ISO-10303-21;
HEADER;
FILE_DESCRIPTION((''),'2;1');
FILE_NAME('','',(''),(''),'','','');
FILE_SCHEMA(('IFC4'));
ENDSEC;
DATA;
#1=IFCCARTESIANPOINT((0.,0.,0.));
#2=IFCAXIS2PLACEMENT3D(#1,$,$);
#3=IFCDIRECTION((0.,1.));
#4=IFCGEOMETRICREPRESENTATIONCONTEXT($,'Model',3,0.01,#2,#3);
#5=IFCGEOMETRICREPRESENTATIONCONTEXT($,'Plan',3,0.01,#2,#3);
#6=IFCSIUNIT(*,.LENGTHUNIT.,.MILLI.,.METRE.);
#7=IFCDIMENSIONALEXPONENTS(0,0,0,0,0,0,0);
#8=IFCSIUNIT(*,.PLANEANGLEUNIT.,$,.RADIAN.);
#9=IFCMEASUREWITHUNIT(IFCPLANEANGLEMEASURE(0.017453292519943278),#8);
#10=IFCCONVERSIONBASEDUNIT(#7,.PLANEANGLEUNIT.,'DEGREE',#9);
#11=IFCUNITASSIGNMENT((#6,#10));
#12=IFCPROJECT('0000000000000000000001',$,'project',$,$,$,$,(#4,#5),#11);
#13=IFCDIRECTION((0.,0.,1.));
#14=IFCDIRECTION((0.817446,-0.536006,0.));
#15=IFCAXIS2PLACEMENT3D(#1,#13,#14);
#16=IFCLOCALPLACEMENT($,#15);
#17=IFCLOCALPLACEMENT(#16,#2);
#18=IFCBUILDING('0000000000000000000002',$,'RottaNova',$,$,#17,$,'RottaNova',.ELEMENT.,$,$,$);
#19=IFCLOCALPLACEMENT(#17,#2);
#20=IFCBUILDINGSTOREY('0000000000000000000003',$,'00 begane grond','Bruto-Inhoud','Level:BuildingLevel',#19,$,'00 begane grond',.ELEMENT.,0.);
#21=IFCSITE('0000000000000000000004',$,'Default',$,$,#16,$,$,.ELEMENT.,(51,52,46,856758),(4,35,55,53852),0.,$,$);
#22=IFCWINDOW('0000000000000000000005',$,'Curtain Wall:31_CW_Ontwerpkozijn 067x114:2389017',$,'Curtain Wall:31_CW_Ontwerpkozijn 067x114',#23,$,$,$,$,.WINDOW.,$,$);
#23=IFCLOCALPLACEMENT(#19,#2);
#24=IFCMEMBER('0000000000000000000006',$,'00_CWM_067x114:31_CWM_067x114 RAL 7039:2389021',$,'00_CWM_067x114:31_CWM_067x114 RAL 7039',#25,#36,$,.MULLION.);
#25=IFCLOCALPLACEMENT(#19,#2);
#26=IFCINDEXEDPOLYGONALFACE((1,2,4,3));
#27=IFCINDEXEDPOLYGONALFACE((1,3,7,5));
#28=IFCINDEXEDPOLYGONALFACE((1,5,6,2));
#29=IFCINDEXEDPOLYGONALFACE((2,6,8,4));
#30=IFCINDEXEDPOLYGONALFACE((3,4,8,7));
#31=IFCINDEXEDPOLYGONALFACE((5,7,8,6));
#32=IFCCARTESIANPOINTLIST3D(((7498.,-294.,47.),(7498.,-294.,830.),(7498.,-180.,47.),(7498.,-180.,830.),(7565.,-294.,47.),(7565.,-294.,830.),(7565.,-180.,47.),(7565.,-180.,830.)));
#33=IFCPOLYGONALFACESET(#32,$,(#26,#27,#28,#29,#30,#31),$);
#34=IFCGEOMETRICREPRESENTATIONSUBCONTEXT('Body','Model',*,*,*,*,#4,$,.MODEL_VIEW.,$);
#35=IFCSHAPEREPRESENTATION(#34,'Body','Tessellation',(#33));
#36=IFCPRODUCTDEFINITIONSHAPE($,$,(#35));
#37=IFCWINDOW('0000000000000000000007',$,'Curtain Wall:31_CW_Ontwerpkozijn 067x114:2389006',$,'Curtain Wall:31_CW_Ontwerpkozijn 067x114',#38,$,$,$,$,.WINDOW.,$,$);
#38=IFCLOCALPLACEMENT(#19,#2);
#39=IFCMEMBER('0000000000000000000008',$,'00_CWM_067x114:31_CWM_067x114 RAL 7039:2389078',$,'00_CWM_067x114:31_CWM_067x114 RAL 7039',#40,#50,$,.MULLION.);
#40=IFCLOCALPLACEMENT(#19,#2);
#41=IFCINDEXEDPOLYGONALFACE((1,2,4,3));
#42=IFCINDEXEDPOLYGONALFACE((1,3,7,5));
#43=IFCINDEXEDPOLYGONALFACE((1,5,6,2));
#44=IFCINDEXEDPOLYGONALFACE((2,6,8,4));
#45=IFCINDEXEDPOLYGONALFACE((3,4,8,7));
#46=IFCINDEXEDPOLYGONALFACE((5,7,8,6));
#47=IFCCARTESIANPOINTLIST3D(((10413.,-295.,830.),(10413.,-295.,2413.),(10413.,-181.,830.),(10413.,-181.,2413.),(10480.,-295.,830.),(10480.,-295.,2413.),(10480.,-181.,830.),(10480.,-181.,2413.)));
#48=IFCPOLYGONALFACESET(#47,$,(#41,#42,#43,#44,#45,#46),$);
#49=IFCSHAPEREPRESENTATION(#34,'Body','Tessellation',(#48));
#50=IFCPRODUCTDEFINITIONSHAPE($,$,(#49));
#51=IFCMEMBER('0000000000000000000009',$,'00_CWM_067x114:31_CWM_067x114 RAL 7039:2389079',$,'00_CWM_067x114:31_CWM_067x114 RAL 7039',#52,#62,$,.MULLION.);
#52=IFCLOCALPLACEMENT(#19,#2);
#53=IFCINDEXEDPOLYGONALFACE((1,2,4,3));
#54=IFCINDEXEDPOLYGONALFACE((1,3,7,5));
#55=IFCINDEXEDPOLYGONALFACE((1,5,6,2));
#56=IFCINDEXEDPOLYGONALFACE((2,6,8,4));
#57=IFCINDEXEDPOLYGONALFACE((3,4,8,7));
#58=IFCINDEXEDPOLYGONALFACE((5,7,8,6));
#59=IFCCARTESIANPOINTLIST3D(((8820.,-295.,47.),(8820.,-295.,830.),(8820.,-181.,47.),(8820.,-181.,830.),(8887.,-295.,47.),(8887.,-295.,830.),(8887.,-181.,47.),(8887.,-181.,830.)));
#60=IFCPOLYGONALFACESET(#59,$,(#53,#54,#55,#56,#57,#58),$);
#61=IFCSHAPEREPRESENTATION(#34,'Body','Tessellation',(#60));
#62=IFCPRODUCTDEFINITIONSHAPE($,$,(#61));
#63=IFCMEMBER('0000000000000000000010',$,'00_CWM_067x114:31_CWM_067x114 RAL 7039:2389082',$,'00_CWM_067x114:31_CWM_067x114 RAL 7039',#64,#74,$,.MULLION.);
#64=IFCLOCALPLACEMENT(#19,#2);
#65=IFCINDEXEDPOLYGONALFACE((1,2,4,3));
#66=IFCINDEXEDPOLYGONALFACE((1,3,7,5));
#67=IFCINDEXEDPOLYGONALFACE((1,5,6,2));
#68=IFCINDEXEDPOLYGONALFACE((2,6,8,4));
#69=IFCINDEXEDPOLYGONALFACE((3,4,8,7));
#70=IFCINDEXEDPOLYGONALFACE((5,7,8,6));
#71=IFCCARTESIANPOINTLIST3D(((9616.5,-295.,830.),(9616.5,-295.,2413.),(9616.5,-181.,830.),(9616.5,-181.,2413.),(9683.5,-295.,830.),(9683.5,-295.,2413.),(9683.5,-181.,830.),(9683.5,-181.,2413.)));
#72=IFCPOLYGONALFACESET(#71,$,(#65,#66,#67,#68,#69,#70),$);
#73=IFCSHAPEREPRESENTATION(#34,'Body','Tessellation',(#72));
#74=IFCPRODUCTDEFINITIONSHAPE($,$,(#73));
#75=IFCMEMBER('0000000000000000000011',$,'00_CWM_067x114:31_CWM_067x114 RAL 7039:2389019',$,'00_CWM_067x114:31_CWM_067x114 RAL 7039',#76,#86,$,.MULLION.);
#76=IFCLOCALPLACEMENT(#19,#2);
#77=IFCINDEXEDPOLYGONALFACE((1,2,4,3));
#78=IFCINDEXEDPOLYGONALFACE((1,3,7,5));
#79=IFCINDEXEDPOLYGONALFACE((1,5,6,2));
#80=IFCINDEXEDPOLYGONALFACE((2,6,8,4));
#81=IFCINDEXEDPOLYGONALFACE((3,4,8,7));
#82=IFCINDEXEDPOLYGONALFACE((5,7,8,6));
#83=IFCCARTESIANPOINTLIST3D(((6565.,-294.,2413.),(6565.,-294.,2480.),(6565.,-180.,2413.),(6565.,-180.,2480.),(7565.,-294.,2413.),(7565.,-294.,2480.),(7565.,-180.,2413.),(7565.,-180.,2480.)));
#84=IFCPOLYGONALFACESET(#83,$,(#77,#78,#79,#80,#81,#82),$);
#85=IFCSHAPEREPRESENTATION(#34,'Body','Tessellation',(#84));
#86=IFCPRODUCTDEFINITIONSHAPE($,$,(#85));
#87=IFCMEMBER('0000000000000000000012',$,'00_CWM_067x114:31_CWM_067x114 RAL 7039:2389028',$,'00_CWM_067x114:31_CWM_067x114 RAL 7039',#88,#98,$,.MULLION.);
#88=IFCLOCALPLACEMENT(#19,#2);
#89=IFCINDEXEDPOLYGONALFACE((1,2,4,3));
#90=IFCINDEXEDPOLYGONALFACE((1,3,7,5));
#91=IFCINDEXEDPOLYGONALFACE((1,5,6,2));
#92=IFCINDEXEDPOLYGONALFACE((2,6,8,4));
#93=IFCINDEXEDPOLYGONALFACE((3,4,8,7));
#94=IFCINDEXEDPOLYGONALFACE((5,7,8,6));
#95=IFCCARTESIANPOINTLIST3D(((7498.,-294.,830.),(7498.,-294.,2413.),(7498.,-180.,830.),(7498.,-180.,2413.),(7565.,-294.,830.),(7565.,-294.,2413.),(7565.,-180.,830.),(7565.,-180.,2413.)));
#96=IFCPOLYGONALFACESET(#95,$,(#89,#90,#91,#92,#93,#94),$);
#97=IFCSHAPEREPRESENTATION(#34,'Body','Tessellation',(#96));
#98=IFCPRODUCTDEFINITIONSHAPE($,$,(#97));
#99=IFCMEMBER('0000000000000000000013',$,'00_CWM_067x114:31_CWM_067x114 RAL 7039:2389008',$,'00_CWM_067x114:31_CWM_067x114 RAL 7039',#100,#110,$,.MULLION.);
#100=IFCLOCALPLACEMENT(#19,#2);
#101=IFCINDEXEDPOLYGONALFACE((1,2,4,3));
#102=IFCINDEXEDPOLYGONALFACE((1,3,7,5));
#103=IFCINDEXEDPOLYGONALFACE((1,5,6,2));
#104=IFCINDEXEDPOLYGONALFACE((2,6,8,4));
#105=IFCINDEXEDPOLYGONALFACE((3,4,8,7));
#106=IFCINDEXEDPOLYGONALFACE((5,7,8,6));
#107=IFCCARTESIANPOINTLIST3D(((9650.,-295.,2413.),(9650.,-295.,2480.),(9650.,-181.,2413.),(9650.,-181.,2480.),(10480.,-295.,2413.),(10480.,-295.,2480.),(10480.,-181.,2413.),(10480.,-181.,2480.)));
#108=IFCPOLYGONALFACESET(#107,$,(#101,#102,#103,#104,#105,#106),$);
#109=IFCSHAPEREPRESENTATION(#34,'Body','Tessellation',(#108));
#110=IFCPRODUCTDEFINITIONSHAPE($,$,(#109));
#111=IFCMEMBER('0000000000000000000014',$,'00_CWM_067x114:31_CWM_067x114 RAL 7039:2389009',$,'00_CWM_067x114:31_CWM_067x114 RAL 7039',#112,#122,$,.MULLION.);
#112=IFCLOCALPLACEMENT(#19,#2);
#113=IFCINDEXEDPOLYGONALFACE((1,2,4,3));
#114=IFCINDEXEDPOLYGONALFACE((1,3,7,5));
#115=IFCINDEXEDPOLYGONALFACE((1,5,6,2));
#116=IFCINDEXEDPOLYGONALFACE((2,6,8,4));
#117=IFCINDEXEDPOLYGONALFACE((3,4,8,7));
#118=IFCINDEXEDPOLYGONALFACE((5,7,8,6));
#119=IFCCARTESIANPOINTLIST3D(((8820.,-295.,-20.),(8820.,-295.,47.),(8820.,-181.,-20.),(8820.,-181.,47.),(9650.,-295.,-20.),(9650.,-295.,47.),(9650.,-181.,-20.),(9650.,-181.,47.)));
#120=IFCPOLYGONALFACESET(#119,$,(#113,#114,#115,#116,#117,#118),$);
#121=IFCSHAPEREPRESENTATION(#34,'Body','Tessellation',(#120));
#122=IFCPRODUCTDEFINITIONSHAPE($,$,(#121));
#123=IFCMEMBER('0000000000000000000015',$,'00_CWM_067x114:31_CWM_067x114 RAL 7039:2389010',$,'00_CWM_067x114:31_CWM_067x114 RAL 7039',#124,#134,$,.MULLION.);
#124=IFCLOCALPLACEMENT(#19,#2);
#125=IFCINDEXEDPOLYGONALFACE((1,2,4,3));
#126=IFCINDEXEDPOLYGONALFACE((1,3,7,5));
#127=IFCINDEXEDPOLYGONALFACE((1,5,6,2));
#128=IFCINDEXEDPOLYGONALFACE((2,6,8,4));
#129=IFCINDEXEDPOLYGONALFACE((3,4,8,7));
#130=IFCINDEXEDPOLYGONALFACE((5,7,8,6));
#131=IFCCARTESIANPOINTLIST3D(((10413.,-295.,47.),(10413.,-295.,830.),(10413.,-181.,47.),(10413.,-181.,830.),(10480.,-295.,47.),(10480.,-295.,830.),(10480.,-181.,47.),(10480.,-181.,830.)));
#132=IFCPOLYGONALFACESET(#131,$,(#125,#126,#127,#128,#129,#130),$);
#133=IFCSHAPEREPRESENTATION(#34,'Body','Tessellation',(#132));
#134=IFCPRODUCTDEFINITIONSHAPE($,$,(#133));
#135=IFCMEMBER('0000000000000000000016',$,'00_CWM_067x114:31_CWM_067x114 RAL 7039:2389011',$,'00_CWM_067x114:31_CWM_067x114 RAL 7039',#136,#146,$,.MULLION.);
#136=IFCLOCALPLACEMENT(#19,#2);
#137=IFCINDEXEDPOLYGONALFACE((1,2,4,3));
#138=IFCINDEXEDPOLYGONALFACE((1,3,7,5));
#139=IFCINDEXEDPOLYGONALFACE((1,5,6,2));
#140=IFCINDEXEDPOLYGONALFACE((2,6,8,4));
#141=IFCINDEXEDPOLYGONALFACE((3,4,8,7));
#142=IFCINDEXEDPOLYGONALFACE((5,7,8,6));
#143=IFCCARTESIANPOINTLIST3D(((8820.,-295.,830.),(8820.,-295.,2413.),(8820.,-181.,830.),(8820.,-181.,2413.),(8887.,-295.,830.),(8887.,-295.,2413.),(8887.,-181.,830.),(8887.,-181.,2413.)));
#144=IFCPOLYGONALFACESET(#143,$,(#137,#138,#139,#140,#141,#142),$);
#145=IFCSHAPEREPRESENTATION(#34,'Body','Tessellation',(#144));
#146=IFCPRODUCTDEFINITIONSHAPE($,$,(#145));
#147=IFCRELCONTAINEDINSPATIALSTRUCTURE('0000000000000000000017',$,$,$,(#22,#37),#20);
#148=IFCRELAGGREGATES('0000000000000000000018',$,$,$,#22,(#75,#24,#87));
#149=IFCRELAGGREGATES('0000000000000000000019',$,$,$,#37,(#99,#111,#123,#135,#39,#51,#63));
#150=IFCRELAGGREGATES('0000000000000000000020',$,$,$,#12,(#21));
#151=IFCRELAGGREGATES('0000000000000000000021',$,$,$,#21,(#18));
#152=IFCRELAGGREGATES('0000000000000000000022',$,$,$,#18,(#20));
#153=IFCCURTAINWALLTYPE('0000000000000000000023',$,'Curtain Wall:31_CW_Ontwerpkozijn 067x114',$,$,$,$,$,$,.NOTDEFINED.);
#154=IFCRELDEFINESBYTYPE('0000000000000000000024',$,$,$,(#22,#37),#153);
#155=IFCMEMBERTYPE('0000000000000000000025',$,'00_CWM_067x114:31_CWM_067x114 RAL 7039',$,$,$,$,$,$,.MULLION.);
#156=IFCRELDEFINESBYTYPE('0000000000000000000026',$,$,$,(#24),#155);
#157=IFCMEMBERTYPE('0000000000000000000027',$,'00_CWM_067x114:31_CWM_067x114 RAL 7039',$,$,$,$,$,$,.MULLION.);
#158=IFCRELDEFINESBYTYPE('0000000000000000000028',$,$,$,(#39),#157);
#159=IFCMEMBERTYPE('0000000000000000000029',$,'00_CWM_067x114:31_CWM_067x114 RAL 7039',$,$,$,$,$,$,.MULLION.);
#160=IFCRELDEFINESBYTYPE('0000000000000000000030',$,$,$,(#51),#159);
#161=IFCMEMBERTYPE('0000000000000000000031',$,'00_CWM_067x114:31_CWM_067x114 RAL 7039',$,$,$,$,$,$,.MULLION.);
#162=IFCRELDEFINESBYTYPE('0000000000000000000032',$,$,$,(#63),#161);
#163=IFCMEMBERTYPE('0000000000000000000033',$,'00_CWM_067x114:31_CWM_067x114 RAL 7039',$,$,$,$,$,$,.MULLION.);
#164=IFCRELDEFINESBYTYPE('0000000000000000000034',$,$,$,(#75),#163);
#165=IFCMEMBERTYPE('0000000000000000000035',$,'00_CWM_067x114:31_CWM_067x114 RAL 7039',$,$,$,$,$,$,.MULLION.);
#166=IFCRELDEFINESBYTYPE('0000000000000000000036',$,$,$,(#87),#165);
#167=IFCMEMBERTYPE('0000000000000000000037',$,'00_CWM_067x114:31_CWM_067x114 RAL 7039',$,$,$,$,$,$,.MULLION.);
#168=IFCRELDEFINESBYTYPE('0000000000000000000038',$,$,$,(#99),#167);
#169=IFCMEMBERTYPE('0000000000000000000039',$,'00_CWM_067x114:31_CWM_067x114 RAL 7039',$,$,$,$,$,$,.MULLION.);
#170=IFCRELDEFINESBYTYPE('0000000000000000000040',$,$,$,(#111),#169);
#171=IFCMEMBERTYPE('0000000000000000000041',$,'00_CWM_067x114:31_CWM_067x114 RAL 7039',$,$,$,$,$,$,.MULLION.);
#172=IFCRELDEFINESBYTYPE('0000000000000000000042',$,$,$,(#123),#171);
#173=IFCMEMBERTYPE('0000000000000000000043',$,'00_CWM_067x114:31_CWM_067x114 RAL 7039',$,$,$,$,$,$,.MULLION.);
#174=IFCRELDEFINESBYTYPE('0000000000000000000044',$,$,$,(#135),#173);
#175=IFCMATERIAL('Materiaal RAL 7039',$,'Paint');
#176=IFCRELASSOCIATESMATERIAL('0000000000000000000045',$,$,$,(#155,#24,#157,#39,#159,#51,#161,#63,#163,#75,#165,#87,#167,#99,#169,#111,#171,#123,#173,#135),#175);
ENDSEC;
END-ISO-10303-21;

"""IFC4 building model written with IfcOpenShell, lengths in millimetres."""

from ifc_helpers import new_model, entity, si_unit, converted_unit, direction, frame, origin, place, context, subcontext, project, spatial, indexed_curve, outline, extrude, source, transform, mapped, material, type_object, type_shapes, element, aggregate, save


model = new_model("IFC4")

# Units and contexts
model_context = context("Model", 3, precision=0.01, world=origin(), true_north=direction((0.0, 1.0)))
plan_context = context("Plan", 3, precision=0.01, world=origin(), true_north=direction((0.0, 1.0)))
body_context = subcontext(model_context, "Body", "Model", "MODEL_VIEW")
ifc_project = project(units=[si_unit("LENGTHUNIT", "METRE", prefix="MILLI"), converted_unit("PLANEANGLEUNIT", "DEGREE", entity("IfcPlaneAngleMeasure", 0.017453292519943278), si_unit("PLANEANGLEUNIT", "RADIAN"), dimensions=[0, 0, 0, 0, 0, 0, 0])], contexts=[model_context, plan_context])

# Site, building, storey
site_placement = place(None, frame((0.0, 0.0, 0.0), z_axis=(0.0, 0.0, 1.0), x_axis=(0.817446, -0.536006, 0.0)))
site = spatial("IfcSite", under=ifc_project, at=site_placement, Name="Default", CompositionType="ELEMENT", RefLatitude=(51, 52, 46, 856758), RefLongitude=(4, 35, 55, 53852), RefElevation=0.0)
building_placement = place(site_placement, origin())
building = spatial("IfcBuilding", under=site, at=building_placement, Name="RottaNova", LongName="RottaNova", CompositionType="ELEMENT")
storey_placement = place(building_placement, origin())
storey = spatial("IfcBuildingStorey", under=building, at=storey_placement, Name="00 begane grond", Description="Bruto-Inhoud", ObjectType="Level:BuildingLevel", LongName="00 begane grond", CompositionType="ELEMENT", Elevation=0.0)

# Window, member
curtain_wall_type = type_object("IfcCurtainWallType", Name="Curtain Wall:31_CW_Ontwerpkozijn 067x114", PredefinedType="NOTDEFINED")
window_1_placement = place(storey_placement, origin())
window_1 = element("IfcWindow", 1, at=window_1_placement, inside=storey, type_object=curtain_wall_type, Name="Curtain Wall:31_CW_Ontwerpkozijn 067x114:2389017", ObjectType="Curtain Wall:31_CW_Ontwerpkozijn 067x114", PredefinedType="WINDOW")
ifc_material_1 = material(Name="Materiaal RAL 7039", Category="Paint")
member_type_1 = type_object("IfcMemberType", Name="00_CWM_067x114:31_CWM_067x114 RAL 7039", PredefinedType="MULLION", material=ifc_material_1)
shared_shape_1 = source(origin(), body_context, "Body", "SweptSolid", [
    extrude(outline(indexed_curve([(-33.5, -57.0), (33.5, -57.0), (33.5, 57.0), (-33.5, 57.0), (-33.5, -57.0)], self_intersect=False)), frame((-33.5, 57.0, -783.0), z_axis=(0.0, 0.0, 1.0), x_axis=(-1.0, 0.0, 0.0)), (0.0, 0.0, 1.0), 783.0),
])
type_shapes(member_type_1, [shared_shape_1])
member_1_placement = place(window_1_placement, frame((7565.0, -180.0, 47.0), z_axis=(0.0, 0.0, -1.0), x_axis=(1.0, 0.0, 0.0)))
member_1 = element("IfcMember", 2, at=member_1_placement, type_object=member_type_1, material=ifc_material_1, Name="00_CWM_067x114:31_CWM_067x114 RAL 7039:2389021", ObjectType="00_CWM_067x114:31_CWM_067x114 RAL 7039", PredefinedType="MULLION", context=body_context, shape_type="MappedRepresentation", body=[
    mapped(shared_shape_1, transform((0.0, 0.0, 0.0), scale=1.0)),
])

# Window, members
window_2_placement = place(storey_placement, origin())
window_2 = element("IfcWindow", 3, at=window_2_placement, inside=storey, type_object=curtain_wall_type, Name="Curtain Wall:31_CW_Ontwerpkozijn 067x114:2389006", ObjectType="Curtain Wall:31_CW_Ontwerpkozijn 067x114", PredefinedType="WINDOW")
member_type_2 = type_object("IfcMemberType", Name="00_CWM_067x114:31_CWM_067x114 RAL 7039", PredefinedType="MULLION", material=ifc_material_1)
shared_shape_2 = source(origin(), body_context, "Body", "SweptSolid", [
    extrude(outline(indexed_curve([(-33.5, -57.0), (33.5, -57.0), (33.5, 57.0), (-33.5, 57.0), (-33.5, -57.0)], self_intersect=False)), frame((-33.5, 57.0, -1583.0), z_axis=(0.0, 0.0, 1.0), x_axis=(-1.0, 0.0, 0.0)), (0.0, 0.0, 1.0), 1583.0),
])
type_shapes(member_type_2, [shared_shape_2])
member_2_placement = place(window_2_placement, frame((10480.0, -181.0, 830.0), z_axis=(0.0, 0.0, -1.0), x_axis=(1.0, 0.0, 0.0)))
member_2 = element("IfcMember", 4, at=member_2_placement, type_object=member_type_2, material=ifc_material_1, Name="00_CWM_067x114:31_CWM_067x114 RAL 7039:2389078", ObjectType="00_CWM_067x114:31_CWM_067x114 RAL 7039", PredefinedType="MULLION", context=body_context, shape_type="MappedRepresentation", body=[
    mapped(shared_shape_2, transform((0.0, 0.0, 0.0), scale=1.0)),
])
member_type_3 = type_object("IfcMemberType", Name="00_CWM_067x114:31_CWM_067x114 RAL 7039", PredefinedType="MULLION", material=ifc_material_1)
shared_shape_3 = source(origin(), body_context, "Body", "SweptSolid", [
    extrude(outline(indexed_curve([(-33.5, -57.0), (33.5, -57.0), (33.5, 57.0), (-33.5, 57.0), (-33.5, -57.0)], self_intersect=False)), frame((-33.5, 57.0, -783.0), z_axis=(0.0, 0.0, 1.0), x_axis=(-1.0, 0.0, 0.0)), (0.0, 0.0, 1.0), 783.0),
])
type_shapes(member_type_3, [shared_shape_3])
member_3_placement = place(window_2_placement, frame((8820.0, -181.0, 830.0), z_axis=(0.0, 0.0, 1.0), x_axis=(-1.0, 0.0, 0.0)))
member_3 = element("IfcMember", 5, at=member_3_placement, type_object=member_type_3, material=ifc_material_1, Name="00_CWM_067x114:31_CWM_067x114 RAL 7039:2389079", ObjectType="00_CWM_067x114:31_CWM_067x114 RAL 7039", PredefinedType="MULLION", context=body_context, shape_type="MappedRepresentation", body=[
    mapped(shared_shape_3, transform((0.0, 0.0, 0.0), scale=1.0)),
])
member_type_4 = type_object("IfcMemberType", Name="00_CWM_067x114:31_CWM_067x114 RAL 7039", PredefinedType="MULLION", material=ifc_material_1)
shared_shape_4 = source(origin(), body_context, "Body", "SweptSolid", [
    extrude(outline(indexed_curve([(-33.5, -57.0), (33.5, -57.0), (33.5, 57.0), (-33.5, 57.0), (-33.5, -57.0)], self_intersect=False)), frame((0.0, 57.0, -1583.0), z_axis=(0.0, 0.0, 1.0), x_axis=(-1.0, 0.0, 0.0)), (0.0, 0.0, 1.0), 1583.0),
])
type_shapes(member_type_4, [shared_shape_4])
member_4_placement = place(window_2_placement, frame((9650.0, -181.0, 830.0), z_axis=(0.0, 0.0, -1.0), x_axis=(1.0, 0.0, 0.0)))
member_4 = element("IfcMember", 6, at=member_4_placement, type_object=member_type_4, material=ifc_material_1, Name="00_CWM_067x114:31_CWM_067x114 RAL 7039:2389082", ObjectType="00_CWM_067x114:31_CWM_067x114 RAL 7039", PredefinedType="MULLION", context=body_context, shape_type="MappedRepresentation", body=[
    mapped(shared_shape_4, transform((0.0, 0.0, 0.0), scale=1.0)),
])

# Members
member_type_5 = type_object("IfcMemberType", Name="00_CWM_067x114:31_CWM_067x114 RAL 7039", PredefinedType="MULLION", material=ifc_material_1)
shared_shape_5 = source(origin(), body_context, "Body", "SweptSolid", [
    extrude(outline(indexed_curve([(-33.5, -57.0), (33.5, -57.0), (33.5, 57.0), (-33.5, 57.0), (-33.5, -57.0)], self_intersect=False)), frame((-33.5, 57.0, -1000.0), z_axis=(0.0, 0.0, 1.0), x_axis=(-1.0, 0.0, 0.0)), (0.0, 0.0, 1.0), 1000.0),
])
type_shapes(member_type_5, [shared_shape_5])
member_5_placement = place(window_1_placement, frame((7565.0, -180.0, 2480.0), z_axis=(1.0, 0.0, 0.0), x_axis=(0.0, 0.0, 1.0)))
member_5 = element("IfcMember", 7, at=member_5_placement, type_object=member_type_5, material=ifc_material_1, Name="00_CWM_067x114:31_CWM_067x114 RAL 7039:2389019", ObjectType="00_CWM_067x114:31_CWM_067x114 RAL 7039", PredefinedType="MULLION", context=body_context, shape_type="MappedRepresentation", body=[
    mapped(shared_shape_5, transform((0.0, 0.0, 0.0), scale=1.0)),
])
member_type_6 = type_object("IfcMemberType", Name="00_CWM_067x114:31_CWM_067x114 RAL 7039", PredefinedType="MULLION", material=ifc_material_1)
shared_shape_6 = source(origin(), body_context, "Body", "SweptSolid", [
    extrude(outline(indexed_curve([(-33.5, -57.0), (33.5, -57.0), (33.5, 57.0), (-33.5, 57.0), (-33.5, -57.0)], self_intersect=False)), frame((-33.5, 57.0, -1583.0), z_axis=(0.0, 0.0, 1.0), x_axis=(-1.0, 0.0, 0.0)), (0.0, 0.0, 1.0), 1583.0),
])
type_shapes(member_type_6, [shared_shape_6])
member_6_placement = place(window_1_placement, frame((7565.0, -180.0, 830.0), z_axis=(0.0, 0.0, -1.0), x_axis=(1.0, 0.0, 0.0)))
member_6 = element("IfcMember", 8, at=member_6_placement, type_object=member_type_6, material=ifc_material_1, Name="00_CWM_067x114:31_CWM_067x114 RAL 7039:2389028", ObjectType="00_CWM_067x114:31_CWM_067x114 RAL 7039", PredefinedType="MULLION", context=body_context, shape_type="MappedRepresentation", body=[
    mapped(shared_shape_6, transform((0.0, 0.0, 0.0), scale=1.0)),
])
aggregate(window_1, [member_5, member_1, member_6])
member_type_7 = type_object("IfcMemberType", Name="00_CWM_067x114:31_CWM_067x114 RAL 7039", PredefinedType="MULLION", material=ifc_material_1)
shared_shape_7 = source(origin(), body_context, "Body", "SweptSolid", [
    extrude(outline(indexed_curve([(-33.5, -57.0), (33.5, -57.0), (33.5, 57.0), (-33.5, 57.0), (-33.5, -57.0)], self_intersect=False)), frame((-33.5, 57.0, -830.0), z_axis=(0.0, 0.0, 1.0), x_axis=(-1.0, 0.0, 0.0)), (0.0, 0.0, 1.0), 830.0),
])
type_shapes(member_type_7, [shared_shape_7])
member_7_placement = place(window_2_placement, frame((10480.0, -181.0, 2480.0), z_axis=(1.0, 0.0, 0.0), x_axis=(0.0, 0.0, 1.0)))
member_7 = element("IfcMember", 9, at=member_7_placement, type_object=member_type_7, material=ifc_material_1, Name="00_CWM_067x114:31_CWM_067x114 RAL 7039:2389008", ObjectType="00_CWM_067x114:31_CWM_067x114 RAL 7039", PredefinedType="MULLION", context=body_context, shape_type="MappedRepresentation", body=[
    mapped(shared_shape_7, transform((0.0, 0.0, 0.0), scale=1.0)),
])
member_type_8 = type_object("IfcMemberType", Name="00_CWM_067x114:31_CWM_067x114 RAL 7039", PredefinedType="MULLION", material=ifc_material_1)
shared_shape_8 = source(origin(), body_context, "Body", "SweptSolid", [
    extrude(outline(indexed_curve([(-33.5, -57.0), (33.5, -57.0), (33.5, 57.0), (-33.5, 57.0), (-33.5, -57.0)], self_intersect=False)), frame((-33.5, 57.0, -830.0), z_axis=(0.0, 0.0, 1.0), x_axis=(-1.0, 0.0, 0.0)), (0.0, 0.0, 1.0), 830.0),
])
type_shapes(member_type_8, [shared_shape_8])
member_8_placement = place(window_2_placement, frame((8820.0, -181.0, -20.0), z_axis=(-1.0, 0.0, 0.0), x_axis=(0.0, 0.0, -1.0)))
member_8 = element("IfcMember", 10, at=member_8_placement, type_object=member_type_8, material=ifc_material_1, Name="00_CWM_067x114:31_CWM_067x114 RAL 7039:2389009", ObjectType="00_CWM_067x114:31_CWM_067x114 RAL 7039", PredefinedType="MULLION", context=body_context, shape_type="MappedRepresentation", body=[
    mapped(shared_shape_8, transform((0.0, 0.0, 0.0), scale=1.0)),
])
member_type_9 = type_object("IfcMemberType", Name="00_CWM_067x114:31_CWM_067x114 RAL 7039", PredefinedType="MULLION", material=ifc_material_1)
shared_shape_9 = source(origin(), body_context, "Body", "SweptSolid", [
    extrude(outline(indexed_curve([(-33.5, -57.0), (33.5, -57.0), (33.5, 57.0), (-33.5, 57.0), (-33.5, -57.0)], self_intersect=False)), frame((-33.5, 57.0, -783.0), z_axis=(0.0, 0.0, 1.0), x_axis=(-1.0, 0.0, 0.0)), (0.0, 0.0, 1.0), 783.0),
])
type_shapes(member_type_9, [shared_shape_9])
member_9_placement = place(window_2_placement, frame((10480.0, -181.0, 47.0), z_axis=(0.0, 0.0, -1.0), x_axis=(1.0, 0.0, 0.0)))
member_9 = element("IfcMember", 11, at=member_9_placement, type_object=member_type_9, material=ifc_material_1, Name="00_CWM_067x114:31_CWM_067x114 RAL 7039:2389010", ObjectType="00_CWM_067x114:31_CWM_067x114 RAL 7039", PredefinedType="MULLION", context=body_context, shape_type="MappedRepresentation", body=[
    mapped(shared_shape_9, transform((0.0, 0.0, 0.0), scale=1.0)),
])
member_type_10 = type_object("IfcMemberType", Name="00_CWM_067x114:31_CWM_067x114 RAL 7039", PredefinedType="MULLION", material=ifc_material_1)
shared_shape_10 = source(origin(), body_context, "Body", "SweptSolid", [
    extrude(outline(indexed_curve([(-33.5, -57.0), (33.5, -57.0), (33.5, 57.0), (-33.5, 57.0), (-33.5, -57.0)], self_intersect=False)), frame((-33.5, 57.0, -1583.0), z_axis=(0.0, 0.0, 1.0), x_axis=(-1.0, 0.0, 0.0)), (0.0, 0.0, 1.0), 1583.0),
])
type_shapes(member_type_10, [shared_shape_10])
member_10_placement = place(window_2_placement, frame((8820.0, -181.0, 2413.0), z_axis=(0.0, 0.0, 1.0), x_axis=(-1.0, 0.0, 0.0)))
member_10 = element("IfcMember", 12, at=member_10_placement, type_object=member_type_10, material=ifc_material_1, Name="00_CWM_067x114:31_CWM_067x114 RAL 7039:2389011", ObjectType="00_CWM_067x114:31_CWM_067x114 RAL 7039", PredefinedType="MULLION", context=body_context, shape_type="MappedRepresentation", body=[
    mapped(shared_shape_10, transform((0.0, 0.0, 0.0), scale=1.0)),
])

aggregate(window_2, [member_7, member_8, member_9, member_10, member_2, member_3, member_4])

save(model, "model.ifc")
